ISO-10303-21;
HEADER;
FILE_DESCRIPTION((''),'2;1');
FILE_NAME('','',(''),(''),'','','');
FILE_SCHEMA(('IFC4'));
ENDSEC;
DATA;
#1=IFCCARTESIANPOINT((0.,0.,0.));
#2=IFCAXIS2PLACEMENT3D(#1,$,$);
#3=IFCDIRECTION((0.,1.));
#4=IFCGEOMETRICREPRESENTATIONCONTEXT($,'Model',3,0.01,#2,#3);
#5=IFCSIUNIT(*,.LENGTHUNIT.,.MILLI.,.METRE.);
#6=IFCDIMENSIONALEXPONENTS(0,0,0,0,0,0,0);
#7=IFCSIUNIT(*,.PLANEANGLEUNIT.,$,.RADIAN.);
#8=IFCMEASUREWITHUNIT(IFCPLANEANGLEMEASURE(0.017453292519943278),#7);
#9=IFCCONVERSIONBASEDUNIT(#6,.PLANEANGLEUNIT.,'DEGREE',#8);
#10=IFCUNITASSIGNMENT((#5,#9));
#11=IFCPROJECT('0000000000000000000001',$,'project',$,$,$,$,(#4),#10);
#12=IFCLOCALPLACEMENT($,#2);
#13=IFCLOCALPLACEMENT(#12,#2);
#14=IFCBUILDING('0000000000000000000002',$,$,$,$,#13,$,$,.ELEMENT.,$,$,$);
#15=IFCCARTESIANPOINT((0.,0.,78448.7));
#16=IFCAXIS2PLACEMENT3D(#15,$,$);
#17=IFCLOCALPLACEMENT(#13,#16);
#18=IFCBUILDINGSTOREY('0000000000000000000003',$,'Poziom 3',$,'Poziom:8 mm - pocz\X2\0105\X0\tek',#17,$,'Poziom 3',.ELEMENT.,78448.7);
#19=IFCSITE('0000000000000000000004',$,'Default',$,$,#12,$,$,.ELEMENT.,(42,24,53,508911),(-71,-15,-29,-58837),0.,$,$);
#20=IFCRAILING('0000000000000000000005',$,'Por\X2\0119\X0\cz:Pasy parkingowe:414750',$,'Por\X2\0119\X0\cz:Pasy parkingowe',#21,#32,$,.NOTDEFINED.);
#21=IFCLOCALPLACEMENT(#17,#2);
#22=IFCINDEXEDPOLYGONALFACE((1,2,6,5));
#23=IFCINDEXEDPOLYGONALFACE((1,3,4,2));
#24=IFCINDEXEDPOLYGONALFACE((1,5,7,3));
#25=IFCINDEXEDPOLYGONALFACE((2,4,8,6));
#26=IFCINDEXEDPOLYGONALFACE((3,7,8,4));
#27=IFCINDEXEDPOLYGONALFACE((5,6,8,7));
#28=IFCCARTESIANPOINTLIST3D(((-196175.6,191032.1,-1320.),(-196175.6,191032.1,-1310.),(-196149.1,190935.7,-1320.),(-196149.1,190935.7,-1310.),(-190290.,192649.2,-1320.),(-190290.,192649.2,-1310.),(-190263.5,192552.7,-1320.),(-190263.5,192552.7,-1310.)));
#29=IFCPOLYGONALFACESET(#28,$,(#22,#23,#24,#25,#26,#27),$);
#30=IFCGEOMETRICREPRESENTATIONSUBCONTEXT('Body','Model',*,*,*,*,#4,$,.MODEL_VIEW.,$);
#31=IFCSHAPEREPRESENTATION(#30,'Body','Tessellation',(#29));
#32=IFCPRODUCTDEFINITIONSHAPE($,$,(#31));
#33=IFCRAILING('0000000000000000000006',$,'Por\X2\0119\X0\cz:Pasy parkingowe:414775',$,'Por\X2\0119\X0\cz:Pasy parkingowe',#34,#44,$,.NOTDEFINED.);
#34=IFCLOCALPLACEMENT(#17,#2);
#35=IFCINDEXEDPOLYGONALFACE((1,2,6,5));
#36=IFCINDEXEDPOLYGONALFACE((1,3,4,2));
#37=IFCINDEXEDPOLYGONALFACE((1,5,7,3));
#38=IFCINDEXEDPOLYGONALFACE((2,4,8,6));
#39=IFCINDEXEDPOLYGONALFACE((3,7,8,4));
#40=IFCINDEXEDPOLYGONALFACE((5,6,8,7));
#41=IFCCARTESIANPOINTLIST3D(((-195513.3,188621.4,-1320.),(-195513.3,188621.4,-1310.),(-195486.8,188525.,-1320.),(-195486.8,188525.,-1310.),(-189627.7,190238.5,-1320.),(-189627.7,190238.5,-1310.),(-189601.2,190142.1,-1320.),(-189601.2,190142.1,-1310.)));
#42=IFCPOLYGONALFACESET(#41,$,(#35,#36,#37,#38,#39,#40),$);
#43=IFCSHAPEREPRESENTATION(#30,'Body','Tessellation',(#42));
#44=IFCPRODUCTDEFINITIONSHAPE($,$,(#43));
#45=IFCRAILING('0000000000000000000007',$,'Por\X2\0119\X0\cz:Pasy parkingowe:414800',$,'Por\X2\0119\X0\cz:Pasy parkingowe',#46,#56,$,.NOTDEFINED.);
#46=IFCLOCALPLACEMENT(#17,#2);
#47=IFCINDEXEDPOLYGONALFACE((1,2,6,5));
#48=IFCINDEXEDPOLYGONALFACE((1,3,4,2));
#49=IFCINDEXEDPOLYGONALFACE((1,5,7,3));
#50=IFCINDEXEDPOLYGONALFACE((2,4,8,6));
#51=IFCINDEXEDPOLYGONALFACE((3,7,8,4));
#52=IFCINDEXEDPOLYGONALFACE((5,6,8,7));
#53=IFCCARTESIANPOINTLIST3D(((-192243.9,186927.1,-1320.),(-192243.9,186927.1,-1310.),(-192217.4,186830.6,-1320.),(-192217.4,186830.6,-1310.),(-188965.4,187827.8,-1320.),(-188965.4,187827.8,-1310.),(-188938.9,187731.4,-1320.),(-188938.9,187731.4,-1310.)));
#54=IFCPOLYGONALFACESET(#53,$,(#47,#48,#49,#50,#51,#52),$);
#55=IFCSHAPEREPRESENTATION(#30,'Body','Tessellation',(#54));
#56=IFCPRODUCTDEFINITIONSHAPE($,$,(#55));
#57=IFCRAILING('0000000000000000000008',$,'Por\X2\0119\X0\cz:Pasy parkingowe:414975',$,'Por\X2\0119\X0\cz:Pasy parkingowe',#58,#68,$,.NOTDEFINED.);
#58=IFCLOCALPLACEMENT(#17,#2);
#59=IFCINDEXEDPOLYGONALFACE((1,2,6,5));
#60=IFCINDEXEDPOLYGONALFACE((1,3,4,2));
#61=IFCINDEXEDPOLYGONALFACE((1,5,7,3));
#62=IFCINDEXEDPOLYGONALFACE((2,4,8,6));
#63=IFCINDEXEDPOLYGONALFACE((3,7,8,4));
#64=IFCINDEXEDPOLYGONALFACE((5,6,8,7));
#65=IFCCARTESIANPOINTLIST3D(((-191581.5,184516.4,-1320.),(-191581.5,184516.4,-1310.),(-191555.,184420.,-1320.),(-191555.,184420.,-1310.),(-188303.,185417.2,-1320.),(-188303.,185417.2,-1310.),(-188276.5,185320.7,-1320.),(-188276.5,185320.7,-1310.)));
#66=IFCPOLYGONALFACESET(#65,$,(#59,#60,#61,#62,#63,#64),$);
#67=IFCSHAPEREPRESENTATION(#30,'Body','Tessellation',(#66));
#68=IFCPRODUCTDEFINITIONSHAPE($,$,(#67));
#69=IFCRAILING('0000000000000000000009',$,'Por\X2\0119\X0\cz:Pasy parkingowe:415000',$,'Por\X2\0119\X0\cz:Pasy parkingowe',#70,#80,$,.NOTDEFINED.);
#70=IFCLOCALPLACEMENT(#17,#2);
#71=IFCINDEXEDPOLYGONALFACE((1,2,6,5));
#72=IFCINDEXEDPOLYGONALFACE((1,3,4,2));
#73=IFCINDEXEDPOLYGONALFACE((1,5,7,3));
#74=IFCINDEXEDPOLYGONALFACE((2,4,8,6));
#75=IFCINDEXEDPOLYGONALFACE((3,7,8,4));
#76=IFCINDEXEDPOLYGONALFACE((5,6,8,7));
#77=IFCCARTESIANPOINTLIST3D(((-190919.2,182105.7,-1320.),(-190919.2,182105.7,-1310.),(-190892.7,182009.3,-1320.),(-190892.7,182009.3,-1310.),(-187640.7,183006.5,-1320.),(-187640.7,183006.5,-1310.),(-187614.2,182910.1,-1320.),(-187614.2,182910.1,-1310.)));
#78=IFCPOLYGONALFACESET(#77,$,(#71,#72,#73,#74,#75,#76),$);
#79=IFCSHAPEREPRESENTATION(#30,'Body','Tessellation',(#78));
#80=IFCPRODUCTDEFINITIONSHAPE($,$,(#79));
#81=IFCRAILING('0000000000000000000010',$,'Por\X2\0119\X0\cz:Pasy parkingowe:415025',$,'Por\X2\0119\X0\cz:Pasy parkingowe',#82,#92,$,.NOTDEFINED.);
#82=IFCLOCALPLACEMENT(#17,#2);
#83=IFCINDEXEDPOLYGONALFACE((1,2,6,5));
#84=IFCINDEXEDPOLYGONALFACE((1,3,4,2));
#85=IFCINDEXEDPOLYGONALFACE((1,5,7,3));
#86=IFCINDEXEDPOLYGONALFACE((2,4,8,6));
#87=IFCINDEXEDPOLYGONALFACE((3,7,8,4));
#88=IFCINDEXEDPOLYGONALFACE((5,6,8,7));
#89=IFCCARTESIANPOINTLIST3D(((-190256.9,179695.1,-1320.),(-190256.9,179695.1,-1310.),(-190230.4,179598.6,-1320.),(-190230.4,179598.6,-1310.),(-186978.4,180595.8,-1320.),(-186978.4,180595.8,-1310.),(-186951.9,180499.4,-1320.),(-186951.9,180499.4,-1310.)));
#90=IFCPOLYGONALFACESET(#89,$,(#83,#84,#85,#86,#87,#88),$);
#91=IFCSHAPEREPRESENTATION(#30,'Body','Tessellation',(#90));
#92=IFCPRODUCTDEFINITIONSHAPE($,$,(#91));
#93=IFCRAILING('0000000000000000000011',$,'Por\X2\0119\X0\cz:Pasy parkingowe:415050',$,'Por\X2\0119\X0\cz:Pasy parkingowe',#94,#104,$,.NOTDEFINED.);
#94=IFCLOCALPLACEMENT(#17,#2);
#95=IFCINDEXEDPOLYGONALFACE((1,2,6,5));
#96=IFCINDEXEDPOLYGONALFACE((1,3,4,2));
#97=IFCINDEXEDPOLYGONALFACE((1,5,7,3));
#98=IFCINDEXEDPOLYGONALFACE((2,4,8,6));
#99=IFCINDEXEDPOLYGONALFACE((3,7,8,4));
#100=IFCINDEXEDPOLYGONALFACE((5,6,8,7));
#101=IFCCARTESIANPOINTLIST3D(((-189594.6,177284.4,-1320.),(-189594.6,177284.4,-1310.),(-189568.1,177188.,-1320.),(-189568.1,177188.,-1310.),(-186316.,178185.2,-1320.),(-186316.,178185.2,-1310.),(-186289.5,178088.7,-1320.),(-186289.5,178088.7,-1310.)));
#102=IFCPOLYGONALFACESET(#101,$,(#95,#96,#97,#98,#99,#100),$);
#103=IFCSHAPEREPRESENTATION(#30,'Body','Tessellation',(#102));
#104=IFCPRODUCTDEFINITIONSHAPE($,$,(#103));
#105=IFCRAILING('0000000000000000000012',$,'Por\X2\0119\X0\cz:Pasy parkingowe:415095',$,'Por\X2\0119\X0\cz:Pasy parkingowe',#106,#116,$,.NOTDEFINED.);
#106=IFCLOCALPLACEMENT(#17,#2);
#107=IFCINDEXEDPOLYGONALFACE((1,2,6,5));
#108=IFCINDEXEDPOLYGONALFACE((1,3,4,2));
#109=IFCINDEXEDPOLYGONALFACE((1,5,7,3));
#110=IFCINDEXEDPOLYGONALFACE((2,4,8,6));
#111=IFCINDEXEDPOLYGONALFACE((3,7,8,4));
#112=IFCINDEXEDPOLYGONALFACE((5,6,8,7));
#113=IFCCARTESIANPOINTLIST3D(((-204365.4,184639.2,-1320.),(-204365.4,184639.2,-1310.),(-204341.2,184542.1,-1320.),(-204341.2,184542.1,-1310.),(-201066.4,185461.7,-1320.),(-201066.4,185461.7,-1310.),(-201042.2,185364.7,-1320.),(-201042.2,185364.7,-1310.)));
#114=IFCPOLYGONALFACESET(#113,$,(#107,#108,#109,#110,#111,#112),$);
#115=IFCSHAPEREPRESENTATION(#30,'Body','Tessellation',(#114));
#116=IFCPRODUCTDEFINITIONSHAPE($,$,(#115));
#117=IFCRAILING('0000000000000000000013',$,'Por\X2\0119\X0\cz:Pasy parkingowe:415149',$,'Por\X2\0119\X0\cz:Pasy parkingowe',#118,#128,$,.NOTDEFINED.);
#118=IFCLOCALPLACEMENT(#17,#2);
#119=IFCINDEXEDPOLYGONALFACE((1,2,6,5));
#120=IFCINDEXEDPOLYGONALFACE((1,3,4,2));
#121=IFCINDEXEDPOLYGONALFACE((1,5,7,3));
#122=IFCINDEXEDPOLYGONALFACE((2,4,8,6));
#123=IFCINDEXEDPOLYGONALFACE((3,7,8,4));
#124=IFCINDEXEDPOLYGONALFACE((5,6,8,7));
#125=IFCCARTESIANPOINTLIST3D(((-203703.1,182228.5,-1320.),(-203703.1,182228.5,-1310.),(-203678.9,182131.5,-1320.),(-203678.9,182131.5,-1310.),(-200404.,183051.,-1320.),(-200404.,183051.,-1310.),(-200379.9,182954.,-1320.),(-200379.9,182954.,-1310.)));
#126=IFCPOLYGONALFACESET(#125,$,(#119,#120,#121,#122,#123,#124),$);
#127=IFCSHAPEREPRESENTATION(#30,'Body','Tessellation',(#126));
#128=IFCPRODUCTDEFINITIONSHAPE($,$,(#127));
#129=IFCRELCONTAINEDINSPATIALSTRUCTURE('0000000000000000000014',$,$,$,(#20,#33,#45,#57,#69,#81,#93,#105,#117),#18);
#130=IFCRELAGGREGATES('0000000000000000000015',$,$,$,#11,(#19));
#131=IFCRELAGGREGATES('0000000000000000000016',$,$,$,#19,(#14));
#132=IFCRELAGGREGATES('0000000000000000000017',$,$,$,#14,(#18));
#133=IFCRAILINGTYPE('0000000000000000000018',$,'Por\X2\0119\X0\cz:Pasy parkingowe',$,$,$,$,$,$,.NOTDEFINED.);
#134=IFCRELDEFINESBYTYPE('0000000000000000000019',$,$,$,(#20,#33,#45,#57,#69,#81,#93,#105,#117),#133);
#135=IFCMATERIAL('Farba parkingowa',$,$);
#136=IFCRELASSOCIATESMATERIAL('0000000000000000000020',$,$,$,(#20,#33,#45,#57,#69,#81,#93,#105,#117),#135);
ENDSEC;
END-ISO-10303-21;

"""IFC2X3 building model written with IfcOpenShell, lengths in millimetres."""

from ifc_helpers import new_model, entity, si_unit, converted_unit, direction, frame, frame_2d, origin, origin_2d_with_axis, place, context, subcontext, project, spatial, rectangle, extrude, material, type_object, element, save


model = new_model("IFC2X3")

# Units and contexts
model_context = context("Model", 3, precision=0.01, world=origin(), true_north=direction((0.0, 1.0)))
body_context = subcontext(model_context, "Body", "Model", "MODEL_VIEW")
ifc_project = project(units=[si_unit("LENGTHUNIT", "METRE", prefix="MILLI"), converted_unit("PLANEANGLEUNIT", "DEGREE", entity("IfcPlaneAngleMeasure", 0.017453292519943278), si_unit("PLANEANGLEUNIT", "RADIAN"), dimensions=[0, 0, 0, 0, 0, 0, 0])], contexts=[model_context])

# Site, building, storey
site_placement = place(None, origin())
site = spatial("IfcSite", under=ifc_project, at=site_placement, Name="Default", CompositionType="ELEMENT", RefLatitude=(42, 24, 53, 508911), RefLongitude=(-71, -15, -29, -58837), RefElevation=0.0)
building_placement = place(site_placement, origin())
building = spatial("IfcBuilding", under=site, at=building_placement, CompositionType="ELEMENT")
storey_placement = place(building_placement, frame((0.0, 0.0, 78448.7)))
storey = spatial("IfcBuildingStorey", under=building, at=storey_placement, Name="Poziom 3", ObjectType="Poziom:8 mm - początek", LongName="Poziom 3", CompositionType="ELEMENT", Elevation=78448.7)

# Railings
ifc_material_1 = material(Name="Farba parkingowa")
railing_type = type_object("IfcRailingType", Name="Poręcz:Pasy parkingowe", PredefinedType="NOTDEFINED")
railing_1_placement = place(storey_placement, origin())
element("IfcRailing", 1, at=railing_1_placement, inside=storey, type_object=railing_type, material=ifc_material_1, Name="Poręcz:Pasy parkingowe:414750", ObjectType="Poręcz:Pasy parkingowe", PredefinedType="NOTDEFINED", context=body_context, shape_type="SweptSolid", body=[
    extrude(rectangle(XDim=6103.7, YDim=100.0, at=frame_2d((0.0, 0.0), x_axis=(1.0, 0.0))), frame((-193219.6, 191792.4, -1320.0), z_axis=(0.0, 0.0, 1.0), x_axis=(0.964267, 0.264931, 0.0)), (0.0, 0.0, 1.0), 10.0),
])
railing_2_placement = place(storey_placement, origin())
element("IfcRailing", 2, at=railing_2_placement, inside=storey, type_object=railing_type, material=ifc_material_1, Name="Poręcz:Pasy parkingowe:414775", ObjectType="Poręcz:Pasy parkingowe", PredefinedType="NOTDEFINED", context=body_context, shape_type="SweptSolid", body=[
    extrude(rectangle(XDim=6103.7, YDim=100.0, at=frame_2d((0.0, 0.0), x_axis=(1.0, 0.0))), frame((-192557.2, 189381.8, -1320.0), z_axis=(0.0, 0.0, 1.0), x_axis=(0.964267, 0.264931, 0.0)), (0.0, 0.0, 1.0), 10.0),
])
railing_3_placement = place(storey_placement, origin())
element("IfcRailing", 3, at=railing_3_placement, inside=storey, type_object=railing_type, material=ifc_material_1, Name="Poręcz:Pasy parkingowe:414800", ObjectType="Poręcz:Pasy parkingowe", PredefinedType="NOTDEFINED", context=body_context, shape_type="SweptSolid", body=[
    extrude(rectangle(XDim=3400.0, YDim=100.0, at=frame_2d((0.0, 0.0), x_axis=(1.0, 0.0))), frame((-190591.4, 187329.2, -1320.0), z_axis=(0.0, 0.0, 1.0), x_axis=(0.964267, 0.264931, 0.0)), (0.0, 0.0, 1.0), 10.0),
])
railing_4_placement = place(storey_placement, origin())
element("IfcRailing", 4, at=railing_4_placement, inside=storey, type_object=railing_type, material=ifc_material_1, Name="Poręcz:Pasy parkingowe:414975", ObjectType="Poręcz:Pasy parkingowe", PredefinedType="NOTDEFINED", context=body_context, shape_type="SweptSolid", body=[
    extrude(rectangle(XDim=3400.0, YDim=100.0, at=origin_2d_with_axis()), frame((-189929.0, 184918.6, -1320.0), z_axis=(0.0, 0.0, 1.0), x_axis=(0.964267, 0.264931, 0.0)), (0.0, 0.0, 1.0), 10.0),
])
railing_5_placement = place(storey_placement, origin())
element("IfcRailing", 5, at=railing_5_placement, inside=storey, type_object=railing_type, material=ifc_material_1, Name="Poręcz:Pasy parkingowe:415000", ObjectType="Poręcz:Pasy parkingowe", PredefinedType="NOTDEFINED", context=body_context, shape_type="SweptSolid", body=[
    extrude(rectangle(XDim=3400.0, YDim=100.0, at=origin_2d_with_axis()), frame((-189266.7, 182507.9, -1320.0), z_axis=(0.0, 0.0, 1.0), x_axis=(0.964267, 0.264931, 0.0)), (0.0, 0.0, 1.0), 10.0),
])
railing_6_placement = place(storey_placement, origin())
element("IfcRailing", 6, at=railing_6_placement, inside=storey, type_object=railing_type, material=ifc_material_1, Name="Poręcz:Pasy parkingowe:415025", ObjectType="Poręcz:Pasy parkingowe", PredefinedType="NOTDEFINED", context=body_context, shape_type="SweptSolid", body=[
    extrude(rectangle(XDim=3400.0, YDim=100.0, at=origin_2d_with_axis()), frame((-188604.4, 180097.2, -1320.0), z_axis=(0.0, 0.0, 1.0), x_axis=(0.964267, 0.264931, 0.0)), (0.0, 0.0, 1.0), 10.0),
])
railing_7_placement = place(storey_placement, origin())
element("IfcRailing", 7, at=railing_7_placement, inside=storey, type_object=railing_type, material=ifc_material_1, Name="Poręcz:Pasy parkingowe:415050", ObjectType="Poręcz:Pasy parkingowe", PredefinedType="NOTDEFINED", context=body_context, shape_type="SweptSolid", body=[
    extrude(rectangle(XDim=3400.0, YDim=100.0, at=origin_2d_with_axis()), frame((-187942.0, 177686.6, -1320.0), z_axis=(0.0, 0.0, 1.0), x_axis=(0.964267, 0.264931, 0.0)), (0.0, 0.0, 1.0), 10.0),
])
railing_8_placement = place(storey_placement, origin())
element("IfcRailing", 8, at=railing_8_placement, inside=storey, type_object=railing_type, material=ifc_material_1, Name="Poręcz:Pasy parkingowe:415095", ObjectType="Poręcz:Pasy parkingowe", PredefinedType="NOTDEFINED", context=body_context, shape_type="SweptSolid", body=[
    extrude(rectangle(XDim=3400.0, YDim=100.0, at=frame_2d((0.0, 0.0), x_axis=(1.0, 0.0))), frame((-202703.8, 185001.9, -1320.0), z_axis=(0.0, 0.0, 1.0), x_axis=(0.970296, 0.241922, 0.0)), (0.0, 0.0, 1.0), 10.0),
])
railing_9_placement = place(storey_placement, origin())
element("IfcRailing", 9, at=railing_9_placement, inside=storey, type_object=railing_type, material=ifc_material_1, Name="Poręcz:Pasy parkingowe:415149", ObjectType="Poręcz:Pasy parkingowe", PredefinedType="NOTDEFINED", context=body_context, shape_type="SweptSolid", body=[
    extrude(rectangle(XDim=3400.0, YDim=100.0, at=frame_2d((0.0, 0.0), x_axis=(1.0, 0.0))), frame((-202041.5, 182591.3, -1320.0), z_axis=(0.0, 0.0, 1.0), x_axis=(0.970296, 0.241922, 0.0)), (0.0, 0.0, 1.0), 10.0),
])

save(model, "model.ifc")
